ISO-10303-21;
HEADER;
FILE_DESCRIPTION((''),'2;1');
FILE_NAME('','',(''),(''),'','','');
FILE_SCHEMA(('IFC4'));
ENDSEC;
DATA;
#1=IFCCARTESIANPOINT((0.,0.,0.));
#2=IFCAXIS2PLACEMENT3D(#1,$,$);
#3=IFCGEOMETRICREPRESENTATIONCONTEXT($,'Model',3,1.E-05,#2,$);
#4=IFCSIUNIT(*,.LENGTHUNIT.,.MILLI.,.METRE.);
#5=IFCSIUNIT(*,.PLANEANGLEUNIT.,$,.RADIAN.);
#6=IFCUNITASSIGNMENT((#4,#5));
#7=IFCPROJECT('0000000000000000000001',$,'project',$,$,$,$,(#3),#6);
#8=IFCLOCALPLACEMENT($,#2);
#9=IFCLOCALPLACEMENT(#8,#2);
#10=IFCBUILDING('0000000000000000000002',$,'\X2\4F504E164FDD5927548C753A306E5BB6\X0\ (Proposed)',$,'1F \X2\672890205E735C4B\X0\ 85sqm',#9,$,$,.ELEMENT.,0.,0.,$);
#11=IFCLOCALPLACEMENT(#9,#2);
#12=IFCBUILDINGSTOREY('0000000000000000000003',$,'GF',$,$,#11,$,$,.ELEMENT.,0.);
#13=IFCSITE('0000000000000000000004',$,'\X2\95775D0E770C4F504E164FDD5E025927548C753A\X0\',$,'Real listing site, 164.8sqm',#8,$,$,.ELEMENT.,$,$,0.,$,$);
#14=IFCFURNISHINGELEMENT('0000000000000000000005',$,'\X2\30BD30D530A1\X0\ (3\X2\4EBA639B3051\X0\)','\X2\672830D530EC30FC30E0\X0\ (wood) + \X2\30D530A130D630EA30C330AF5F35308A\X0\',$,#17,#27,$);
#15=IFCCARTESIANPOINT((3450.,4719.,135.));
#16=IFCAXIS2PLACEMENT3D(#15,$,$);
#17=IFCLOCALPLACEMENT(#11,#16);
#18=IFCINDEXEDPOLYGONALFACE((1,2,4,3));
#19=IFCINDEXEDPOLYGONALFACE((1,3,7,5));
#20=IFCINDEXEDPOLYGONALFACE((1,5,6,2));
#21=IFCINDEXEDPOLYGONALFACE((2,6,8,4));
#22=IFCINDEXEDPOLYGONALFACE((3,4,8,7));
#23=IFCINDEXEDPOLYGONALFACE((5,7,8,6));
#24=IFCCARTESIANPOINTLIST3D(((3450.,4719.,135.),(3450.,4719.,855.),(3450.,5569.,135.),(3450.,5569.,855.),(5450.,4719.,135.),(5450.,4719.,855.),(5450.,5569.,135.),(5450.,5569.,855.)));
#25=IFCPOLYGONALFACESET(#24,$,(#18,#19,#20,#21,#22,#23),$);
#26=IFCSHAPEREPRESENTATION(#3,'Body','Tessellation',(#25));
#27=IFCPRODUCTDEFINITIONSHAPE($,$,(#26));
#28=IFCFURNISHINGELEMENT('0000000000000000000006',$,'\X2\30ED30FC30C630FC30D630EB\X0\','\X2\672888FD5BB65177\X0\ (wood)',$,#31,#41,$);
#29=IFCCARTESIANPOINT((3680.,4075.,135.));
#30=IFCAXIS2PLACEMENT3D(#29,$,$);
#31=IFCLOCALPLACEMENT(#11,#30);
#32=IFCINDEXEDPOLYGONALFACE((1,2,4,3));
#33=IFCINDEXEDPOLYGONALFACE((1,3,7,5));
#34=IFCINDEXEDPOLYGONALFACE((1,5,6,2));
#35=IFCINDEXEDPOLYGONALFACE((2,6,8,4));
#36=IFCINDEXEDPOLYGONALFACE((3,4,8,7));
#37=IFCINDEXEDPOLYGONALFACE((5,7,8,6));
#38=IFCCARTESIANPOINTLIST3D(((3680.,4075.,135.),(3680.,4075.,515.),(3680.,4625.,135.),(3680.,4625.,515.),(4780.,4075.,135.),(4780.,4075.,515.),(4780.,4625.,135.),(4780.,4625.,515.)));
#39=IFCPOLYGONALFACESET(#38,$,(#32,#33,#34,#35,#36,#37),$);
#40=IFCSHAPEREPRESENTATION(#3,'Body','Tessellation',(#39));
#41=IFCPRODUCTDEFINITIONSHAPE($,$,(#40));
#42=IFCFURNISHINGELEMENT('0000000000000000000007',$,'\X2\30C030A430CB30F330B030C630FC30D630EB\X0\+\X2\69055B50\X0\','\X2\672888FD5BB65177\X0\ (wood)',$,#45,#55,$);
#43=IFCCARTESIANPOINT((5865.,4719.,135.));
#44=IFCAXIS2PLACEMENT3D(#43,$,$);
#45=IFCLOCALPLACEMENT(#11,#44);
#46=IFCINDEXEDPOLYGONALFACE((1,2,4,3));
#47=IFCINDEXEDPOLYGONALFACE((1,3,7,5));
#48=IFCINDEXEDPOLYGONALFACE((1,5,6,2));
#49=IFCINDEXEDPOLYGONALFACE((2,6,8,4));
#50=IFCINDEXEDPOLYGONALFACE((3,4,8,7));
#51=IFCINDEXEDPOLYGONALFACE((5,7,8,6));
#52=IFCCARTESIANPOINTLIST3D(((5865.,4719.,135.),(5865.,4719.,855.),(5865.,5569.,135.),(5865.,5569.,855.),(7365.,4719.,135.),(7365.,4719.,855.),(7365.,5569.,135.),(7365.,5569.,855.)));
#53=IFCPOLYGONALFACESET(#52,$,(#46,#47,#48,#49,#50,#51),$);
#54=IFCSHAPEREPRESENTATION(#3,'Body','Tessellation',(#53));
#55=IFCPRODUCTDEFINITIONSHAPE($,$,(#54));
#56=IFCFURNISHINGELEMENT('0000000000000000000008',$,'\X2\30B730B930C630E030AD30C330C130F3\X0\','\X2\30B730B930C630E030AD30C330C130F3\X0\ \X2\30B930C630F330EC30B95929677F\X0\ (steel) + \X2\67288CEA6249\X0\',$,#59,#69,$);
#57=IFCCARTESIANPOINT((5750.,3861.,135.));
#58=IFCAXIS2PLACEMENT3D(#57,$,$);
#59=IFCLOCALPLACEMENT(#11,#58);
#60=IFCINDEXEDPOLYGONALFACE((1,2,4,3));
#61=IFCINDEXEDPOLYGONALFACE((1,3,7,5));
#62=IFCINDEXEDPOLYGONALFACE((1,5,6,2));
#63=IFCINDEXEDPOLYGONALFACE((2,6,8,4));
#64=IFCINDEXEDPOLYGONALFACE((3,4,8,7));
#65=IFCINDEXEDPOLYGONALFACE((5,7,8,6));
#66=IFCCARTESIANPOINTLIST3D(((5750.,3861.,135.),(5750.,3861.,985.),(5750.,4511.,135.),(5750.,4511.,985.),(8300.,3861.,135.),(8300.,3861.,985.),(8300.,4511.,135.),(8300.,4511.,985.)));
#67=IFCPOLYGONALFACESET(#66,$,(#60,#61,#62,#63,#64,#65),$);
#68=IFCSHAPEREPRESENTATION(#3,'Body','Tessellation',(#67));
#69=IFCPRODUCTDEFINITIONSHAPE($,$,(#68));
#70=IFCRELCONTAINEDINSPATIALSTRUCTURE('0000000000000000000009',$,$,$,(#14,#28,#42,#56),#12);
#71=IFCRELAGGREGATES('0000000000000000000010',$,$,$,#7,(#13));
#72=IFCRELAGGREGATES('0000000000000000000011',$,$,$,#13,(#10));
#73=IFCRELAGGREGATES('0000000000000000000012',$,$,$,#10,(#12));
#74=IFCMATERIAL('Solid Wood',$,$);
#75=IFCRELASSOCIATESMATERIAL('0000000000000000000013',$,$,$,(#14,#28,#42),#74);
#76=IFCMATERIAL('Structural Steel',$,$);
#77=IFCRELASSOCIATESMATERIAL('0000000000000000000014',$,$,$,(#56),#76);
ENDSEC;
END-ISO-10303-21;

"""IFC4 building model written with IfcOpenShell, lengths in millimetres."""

from ifc_helpers import new_model, si_unit, frame, frame_2d, origin, place, context, project, spatial, rectangle, extrude, material, element, save


model = new_model("IFC4")

# Units and contexts
model_context = context("Model", 3, precision=1e-05, world=origin())
ifc_project = project(units=[si_unit("LENGTHUNIT", "METRE", prefix="MILLI"), si_unit("PLANEANGLEUNIT", "RADIAN")], contexts=[model_context])

# Site, building, storey
site_placement = place(None, origin())
site = spatial("IfcSite", under=ifc_project, at=site_placement, Name="長崎県佐世保市大和町", ObjectType="Real listing site, 164.8sqm", CompositionType="ELEMENT", RefElevation=0.0)
building_placement = place(site_placement, origin())
building = spatial("IfcBuilding", under=site, at=building_placement, Name="佐世保大和町の家 (Proposed)", ObjectType="1F 木造平屋 85sqm", CompositionType="ELEMENT", ElevationOfRefHeight=0.0, ElevationOfTerrain=0.0)
storey_placement = place(building_placement, origin())
storey = spatial("IfcBuildingStorey", under=building, at=storey_placement, Name="GF", CompositionType="ELEMENT", Elevation=0.0)

# Shared definitions
ifc_material_1 = material(Name="Solid Wood")

# Shared definitions
ifc_material_2 = material(Name="Structural Steel")

# Furnishing elements
furnishing_1_placement = place(storey_placement, frame((3450.0, 4719.0, 135.0)))
element("IfcFurnishingElement", 1, at=furnishing_1_placement, inside=storey, material=ifc_material_1, Name="ソファ (3人掛け)", Description="木フレーム (wood) + ファブリック張り", context=model_context, shape_type="SweptSolid", body=[
    extrude(rectangle(XDim=2000.0, YDim=850.0, at=frame_2d((1000.0, 425.0))), frame((3450.0, 4719.0, 135.0)), (0.0, 0.0, 1.0), 720.0),
])
furnishing_2_placement = place(storey_placement, frame((3680.0, 4075.0, 135.0)))
element("IfcFurnishingElement", 2, at=furnishing_2_placement, inside=storey, material=ifc_material_1, Name="ローテーブル", Description="木製家具 (wood)", context=model_context, shape_type="SweptSolid", body=[
    extrude(rectangle(XDim=1100.0, YDim=550.0, at=frame_2d((550.0, 275.0))), frame((3680.0, 4075.0, 135.0)), (0.0, 0.0, 1.0), 380.0),
])
furnishing_3_placement = place(storey_placement, frame((5865.0, 4719.0, 135.0)))
element("IfcFurnishingElement", 3, at=furnishing_3_placement, inside=storey, material=ifc_material_1, Name="ダイニングテーブル+椅子", Description="木製家具 (wood)", context=model_context, shape_type="SweptSolid", body=[
    extrude(rectangle(XDim=1500.0, YDim=850.0, at=frame_2d((750.0, 425.0))), frame((5865.0, 4719.0, 135.0)), (0.0, 0.0, 1.0), 720.0),
])
furnishing_4_placement = place(storey_placement, frame((5750.0, 3861.0, 135.0)))
element("IfcFurnishingElement", 4, at=furnishing_4_placement, inside=storey, material=ifc_material_2, Name="システムキッチン", Description="システムキッチン ステンレス天板 (steel) + 木質扉", context=model_context, shape_type="SweptSolid", body=[
    extrude(rectangle(XDim=2550.0, YDim=650.0, at=frame_2d((1275.0, 325.0))), frame((5750.0, 3861.0, 135.0)), (0.0, 0.0, 1.0), 850.0),
])

save(model, "model.ifc")
